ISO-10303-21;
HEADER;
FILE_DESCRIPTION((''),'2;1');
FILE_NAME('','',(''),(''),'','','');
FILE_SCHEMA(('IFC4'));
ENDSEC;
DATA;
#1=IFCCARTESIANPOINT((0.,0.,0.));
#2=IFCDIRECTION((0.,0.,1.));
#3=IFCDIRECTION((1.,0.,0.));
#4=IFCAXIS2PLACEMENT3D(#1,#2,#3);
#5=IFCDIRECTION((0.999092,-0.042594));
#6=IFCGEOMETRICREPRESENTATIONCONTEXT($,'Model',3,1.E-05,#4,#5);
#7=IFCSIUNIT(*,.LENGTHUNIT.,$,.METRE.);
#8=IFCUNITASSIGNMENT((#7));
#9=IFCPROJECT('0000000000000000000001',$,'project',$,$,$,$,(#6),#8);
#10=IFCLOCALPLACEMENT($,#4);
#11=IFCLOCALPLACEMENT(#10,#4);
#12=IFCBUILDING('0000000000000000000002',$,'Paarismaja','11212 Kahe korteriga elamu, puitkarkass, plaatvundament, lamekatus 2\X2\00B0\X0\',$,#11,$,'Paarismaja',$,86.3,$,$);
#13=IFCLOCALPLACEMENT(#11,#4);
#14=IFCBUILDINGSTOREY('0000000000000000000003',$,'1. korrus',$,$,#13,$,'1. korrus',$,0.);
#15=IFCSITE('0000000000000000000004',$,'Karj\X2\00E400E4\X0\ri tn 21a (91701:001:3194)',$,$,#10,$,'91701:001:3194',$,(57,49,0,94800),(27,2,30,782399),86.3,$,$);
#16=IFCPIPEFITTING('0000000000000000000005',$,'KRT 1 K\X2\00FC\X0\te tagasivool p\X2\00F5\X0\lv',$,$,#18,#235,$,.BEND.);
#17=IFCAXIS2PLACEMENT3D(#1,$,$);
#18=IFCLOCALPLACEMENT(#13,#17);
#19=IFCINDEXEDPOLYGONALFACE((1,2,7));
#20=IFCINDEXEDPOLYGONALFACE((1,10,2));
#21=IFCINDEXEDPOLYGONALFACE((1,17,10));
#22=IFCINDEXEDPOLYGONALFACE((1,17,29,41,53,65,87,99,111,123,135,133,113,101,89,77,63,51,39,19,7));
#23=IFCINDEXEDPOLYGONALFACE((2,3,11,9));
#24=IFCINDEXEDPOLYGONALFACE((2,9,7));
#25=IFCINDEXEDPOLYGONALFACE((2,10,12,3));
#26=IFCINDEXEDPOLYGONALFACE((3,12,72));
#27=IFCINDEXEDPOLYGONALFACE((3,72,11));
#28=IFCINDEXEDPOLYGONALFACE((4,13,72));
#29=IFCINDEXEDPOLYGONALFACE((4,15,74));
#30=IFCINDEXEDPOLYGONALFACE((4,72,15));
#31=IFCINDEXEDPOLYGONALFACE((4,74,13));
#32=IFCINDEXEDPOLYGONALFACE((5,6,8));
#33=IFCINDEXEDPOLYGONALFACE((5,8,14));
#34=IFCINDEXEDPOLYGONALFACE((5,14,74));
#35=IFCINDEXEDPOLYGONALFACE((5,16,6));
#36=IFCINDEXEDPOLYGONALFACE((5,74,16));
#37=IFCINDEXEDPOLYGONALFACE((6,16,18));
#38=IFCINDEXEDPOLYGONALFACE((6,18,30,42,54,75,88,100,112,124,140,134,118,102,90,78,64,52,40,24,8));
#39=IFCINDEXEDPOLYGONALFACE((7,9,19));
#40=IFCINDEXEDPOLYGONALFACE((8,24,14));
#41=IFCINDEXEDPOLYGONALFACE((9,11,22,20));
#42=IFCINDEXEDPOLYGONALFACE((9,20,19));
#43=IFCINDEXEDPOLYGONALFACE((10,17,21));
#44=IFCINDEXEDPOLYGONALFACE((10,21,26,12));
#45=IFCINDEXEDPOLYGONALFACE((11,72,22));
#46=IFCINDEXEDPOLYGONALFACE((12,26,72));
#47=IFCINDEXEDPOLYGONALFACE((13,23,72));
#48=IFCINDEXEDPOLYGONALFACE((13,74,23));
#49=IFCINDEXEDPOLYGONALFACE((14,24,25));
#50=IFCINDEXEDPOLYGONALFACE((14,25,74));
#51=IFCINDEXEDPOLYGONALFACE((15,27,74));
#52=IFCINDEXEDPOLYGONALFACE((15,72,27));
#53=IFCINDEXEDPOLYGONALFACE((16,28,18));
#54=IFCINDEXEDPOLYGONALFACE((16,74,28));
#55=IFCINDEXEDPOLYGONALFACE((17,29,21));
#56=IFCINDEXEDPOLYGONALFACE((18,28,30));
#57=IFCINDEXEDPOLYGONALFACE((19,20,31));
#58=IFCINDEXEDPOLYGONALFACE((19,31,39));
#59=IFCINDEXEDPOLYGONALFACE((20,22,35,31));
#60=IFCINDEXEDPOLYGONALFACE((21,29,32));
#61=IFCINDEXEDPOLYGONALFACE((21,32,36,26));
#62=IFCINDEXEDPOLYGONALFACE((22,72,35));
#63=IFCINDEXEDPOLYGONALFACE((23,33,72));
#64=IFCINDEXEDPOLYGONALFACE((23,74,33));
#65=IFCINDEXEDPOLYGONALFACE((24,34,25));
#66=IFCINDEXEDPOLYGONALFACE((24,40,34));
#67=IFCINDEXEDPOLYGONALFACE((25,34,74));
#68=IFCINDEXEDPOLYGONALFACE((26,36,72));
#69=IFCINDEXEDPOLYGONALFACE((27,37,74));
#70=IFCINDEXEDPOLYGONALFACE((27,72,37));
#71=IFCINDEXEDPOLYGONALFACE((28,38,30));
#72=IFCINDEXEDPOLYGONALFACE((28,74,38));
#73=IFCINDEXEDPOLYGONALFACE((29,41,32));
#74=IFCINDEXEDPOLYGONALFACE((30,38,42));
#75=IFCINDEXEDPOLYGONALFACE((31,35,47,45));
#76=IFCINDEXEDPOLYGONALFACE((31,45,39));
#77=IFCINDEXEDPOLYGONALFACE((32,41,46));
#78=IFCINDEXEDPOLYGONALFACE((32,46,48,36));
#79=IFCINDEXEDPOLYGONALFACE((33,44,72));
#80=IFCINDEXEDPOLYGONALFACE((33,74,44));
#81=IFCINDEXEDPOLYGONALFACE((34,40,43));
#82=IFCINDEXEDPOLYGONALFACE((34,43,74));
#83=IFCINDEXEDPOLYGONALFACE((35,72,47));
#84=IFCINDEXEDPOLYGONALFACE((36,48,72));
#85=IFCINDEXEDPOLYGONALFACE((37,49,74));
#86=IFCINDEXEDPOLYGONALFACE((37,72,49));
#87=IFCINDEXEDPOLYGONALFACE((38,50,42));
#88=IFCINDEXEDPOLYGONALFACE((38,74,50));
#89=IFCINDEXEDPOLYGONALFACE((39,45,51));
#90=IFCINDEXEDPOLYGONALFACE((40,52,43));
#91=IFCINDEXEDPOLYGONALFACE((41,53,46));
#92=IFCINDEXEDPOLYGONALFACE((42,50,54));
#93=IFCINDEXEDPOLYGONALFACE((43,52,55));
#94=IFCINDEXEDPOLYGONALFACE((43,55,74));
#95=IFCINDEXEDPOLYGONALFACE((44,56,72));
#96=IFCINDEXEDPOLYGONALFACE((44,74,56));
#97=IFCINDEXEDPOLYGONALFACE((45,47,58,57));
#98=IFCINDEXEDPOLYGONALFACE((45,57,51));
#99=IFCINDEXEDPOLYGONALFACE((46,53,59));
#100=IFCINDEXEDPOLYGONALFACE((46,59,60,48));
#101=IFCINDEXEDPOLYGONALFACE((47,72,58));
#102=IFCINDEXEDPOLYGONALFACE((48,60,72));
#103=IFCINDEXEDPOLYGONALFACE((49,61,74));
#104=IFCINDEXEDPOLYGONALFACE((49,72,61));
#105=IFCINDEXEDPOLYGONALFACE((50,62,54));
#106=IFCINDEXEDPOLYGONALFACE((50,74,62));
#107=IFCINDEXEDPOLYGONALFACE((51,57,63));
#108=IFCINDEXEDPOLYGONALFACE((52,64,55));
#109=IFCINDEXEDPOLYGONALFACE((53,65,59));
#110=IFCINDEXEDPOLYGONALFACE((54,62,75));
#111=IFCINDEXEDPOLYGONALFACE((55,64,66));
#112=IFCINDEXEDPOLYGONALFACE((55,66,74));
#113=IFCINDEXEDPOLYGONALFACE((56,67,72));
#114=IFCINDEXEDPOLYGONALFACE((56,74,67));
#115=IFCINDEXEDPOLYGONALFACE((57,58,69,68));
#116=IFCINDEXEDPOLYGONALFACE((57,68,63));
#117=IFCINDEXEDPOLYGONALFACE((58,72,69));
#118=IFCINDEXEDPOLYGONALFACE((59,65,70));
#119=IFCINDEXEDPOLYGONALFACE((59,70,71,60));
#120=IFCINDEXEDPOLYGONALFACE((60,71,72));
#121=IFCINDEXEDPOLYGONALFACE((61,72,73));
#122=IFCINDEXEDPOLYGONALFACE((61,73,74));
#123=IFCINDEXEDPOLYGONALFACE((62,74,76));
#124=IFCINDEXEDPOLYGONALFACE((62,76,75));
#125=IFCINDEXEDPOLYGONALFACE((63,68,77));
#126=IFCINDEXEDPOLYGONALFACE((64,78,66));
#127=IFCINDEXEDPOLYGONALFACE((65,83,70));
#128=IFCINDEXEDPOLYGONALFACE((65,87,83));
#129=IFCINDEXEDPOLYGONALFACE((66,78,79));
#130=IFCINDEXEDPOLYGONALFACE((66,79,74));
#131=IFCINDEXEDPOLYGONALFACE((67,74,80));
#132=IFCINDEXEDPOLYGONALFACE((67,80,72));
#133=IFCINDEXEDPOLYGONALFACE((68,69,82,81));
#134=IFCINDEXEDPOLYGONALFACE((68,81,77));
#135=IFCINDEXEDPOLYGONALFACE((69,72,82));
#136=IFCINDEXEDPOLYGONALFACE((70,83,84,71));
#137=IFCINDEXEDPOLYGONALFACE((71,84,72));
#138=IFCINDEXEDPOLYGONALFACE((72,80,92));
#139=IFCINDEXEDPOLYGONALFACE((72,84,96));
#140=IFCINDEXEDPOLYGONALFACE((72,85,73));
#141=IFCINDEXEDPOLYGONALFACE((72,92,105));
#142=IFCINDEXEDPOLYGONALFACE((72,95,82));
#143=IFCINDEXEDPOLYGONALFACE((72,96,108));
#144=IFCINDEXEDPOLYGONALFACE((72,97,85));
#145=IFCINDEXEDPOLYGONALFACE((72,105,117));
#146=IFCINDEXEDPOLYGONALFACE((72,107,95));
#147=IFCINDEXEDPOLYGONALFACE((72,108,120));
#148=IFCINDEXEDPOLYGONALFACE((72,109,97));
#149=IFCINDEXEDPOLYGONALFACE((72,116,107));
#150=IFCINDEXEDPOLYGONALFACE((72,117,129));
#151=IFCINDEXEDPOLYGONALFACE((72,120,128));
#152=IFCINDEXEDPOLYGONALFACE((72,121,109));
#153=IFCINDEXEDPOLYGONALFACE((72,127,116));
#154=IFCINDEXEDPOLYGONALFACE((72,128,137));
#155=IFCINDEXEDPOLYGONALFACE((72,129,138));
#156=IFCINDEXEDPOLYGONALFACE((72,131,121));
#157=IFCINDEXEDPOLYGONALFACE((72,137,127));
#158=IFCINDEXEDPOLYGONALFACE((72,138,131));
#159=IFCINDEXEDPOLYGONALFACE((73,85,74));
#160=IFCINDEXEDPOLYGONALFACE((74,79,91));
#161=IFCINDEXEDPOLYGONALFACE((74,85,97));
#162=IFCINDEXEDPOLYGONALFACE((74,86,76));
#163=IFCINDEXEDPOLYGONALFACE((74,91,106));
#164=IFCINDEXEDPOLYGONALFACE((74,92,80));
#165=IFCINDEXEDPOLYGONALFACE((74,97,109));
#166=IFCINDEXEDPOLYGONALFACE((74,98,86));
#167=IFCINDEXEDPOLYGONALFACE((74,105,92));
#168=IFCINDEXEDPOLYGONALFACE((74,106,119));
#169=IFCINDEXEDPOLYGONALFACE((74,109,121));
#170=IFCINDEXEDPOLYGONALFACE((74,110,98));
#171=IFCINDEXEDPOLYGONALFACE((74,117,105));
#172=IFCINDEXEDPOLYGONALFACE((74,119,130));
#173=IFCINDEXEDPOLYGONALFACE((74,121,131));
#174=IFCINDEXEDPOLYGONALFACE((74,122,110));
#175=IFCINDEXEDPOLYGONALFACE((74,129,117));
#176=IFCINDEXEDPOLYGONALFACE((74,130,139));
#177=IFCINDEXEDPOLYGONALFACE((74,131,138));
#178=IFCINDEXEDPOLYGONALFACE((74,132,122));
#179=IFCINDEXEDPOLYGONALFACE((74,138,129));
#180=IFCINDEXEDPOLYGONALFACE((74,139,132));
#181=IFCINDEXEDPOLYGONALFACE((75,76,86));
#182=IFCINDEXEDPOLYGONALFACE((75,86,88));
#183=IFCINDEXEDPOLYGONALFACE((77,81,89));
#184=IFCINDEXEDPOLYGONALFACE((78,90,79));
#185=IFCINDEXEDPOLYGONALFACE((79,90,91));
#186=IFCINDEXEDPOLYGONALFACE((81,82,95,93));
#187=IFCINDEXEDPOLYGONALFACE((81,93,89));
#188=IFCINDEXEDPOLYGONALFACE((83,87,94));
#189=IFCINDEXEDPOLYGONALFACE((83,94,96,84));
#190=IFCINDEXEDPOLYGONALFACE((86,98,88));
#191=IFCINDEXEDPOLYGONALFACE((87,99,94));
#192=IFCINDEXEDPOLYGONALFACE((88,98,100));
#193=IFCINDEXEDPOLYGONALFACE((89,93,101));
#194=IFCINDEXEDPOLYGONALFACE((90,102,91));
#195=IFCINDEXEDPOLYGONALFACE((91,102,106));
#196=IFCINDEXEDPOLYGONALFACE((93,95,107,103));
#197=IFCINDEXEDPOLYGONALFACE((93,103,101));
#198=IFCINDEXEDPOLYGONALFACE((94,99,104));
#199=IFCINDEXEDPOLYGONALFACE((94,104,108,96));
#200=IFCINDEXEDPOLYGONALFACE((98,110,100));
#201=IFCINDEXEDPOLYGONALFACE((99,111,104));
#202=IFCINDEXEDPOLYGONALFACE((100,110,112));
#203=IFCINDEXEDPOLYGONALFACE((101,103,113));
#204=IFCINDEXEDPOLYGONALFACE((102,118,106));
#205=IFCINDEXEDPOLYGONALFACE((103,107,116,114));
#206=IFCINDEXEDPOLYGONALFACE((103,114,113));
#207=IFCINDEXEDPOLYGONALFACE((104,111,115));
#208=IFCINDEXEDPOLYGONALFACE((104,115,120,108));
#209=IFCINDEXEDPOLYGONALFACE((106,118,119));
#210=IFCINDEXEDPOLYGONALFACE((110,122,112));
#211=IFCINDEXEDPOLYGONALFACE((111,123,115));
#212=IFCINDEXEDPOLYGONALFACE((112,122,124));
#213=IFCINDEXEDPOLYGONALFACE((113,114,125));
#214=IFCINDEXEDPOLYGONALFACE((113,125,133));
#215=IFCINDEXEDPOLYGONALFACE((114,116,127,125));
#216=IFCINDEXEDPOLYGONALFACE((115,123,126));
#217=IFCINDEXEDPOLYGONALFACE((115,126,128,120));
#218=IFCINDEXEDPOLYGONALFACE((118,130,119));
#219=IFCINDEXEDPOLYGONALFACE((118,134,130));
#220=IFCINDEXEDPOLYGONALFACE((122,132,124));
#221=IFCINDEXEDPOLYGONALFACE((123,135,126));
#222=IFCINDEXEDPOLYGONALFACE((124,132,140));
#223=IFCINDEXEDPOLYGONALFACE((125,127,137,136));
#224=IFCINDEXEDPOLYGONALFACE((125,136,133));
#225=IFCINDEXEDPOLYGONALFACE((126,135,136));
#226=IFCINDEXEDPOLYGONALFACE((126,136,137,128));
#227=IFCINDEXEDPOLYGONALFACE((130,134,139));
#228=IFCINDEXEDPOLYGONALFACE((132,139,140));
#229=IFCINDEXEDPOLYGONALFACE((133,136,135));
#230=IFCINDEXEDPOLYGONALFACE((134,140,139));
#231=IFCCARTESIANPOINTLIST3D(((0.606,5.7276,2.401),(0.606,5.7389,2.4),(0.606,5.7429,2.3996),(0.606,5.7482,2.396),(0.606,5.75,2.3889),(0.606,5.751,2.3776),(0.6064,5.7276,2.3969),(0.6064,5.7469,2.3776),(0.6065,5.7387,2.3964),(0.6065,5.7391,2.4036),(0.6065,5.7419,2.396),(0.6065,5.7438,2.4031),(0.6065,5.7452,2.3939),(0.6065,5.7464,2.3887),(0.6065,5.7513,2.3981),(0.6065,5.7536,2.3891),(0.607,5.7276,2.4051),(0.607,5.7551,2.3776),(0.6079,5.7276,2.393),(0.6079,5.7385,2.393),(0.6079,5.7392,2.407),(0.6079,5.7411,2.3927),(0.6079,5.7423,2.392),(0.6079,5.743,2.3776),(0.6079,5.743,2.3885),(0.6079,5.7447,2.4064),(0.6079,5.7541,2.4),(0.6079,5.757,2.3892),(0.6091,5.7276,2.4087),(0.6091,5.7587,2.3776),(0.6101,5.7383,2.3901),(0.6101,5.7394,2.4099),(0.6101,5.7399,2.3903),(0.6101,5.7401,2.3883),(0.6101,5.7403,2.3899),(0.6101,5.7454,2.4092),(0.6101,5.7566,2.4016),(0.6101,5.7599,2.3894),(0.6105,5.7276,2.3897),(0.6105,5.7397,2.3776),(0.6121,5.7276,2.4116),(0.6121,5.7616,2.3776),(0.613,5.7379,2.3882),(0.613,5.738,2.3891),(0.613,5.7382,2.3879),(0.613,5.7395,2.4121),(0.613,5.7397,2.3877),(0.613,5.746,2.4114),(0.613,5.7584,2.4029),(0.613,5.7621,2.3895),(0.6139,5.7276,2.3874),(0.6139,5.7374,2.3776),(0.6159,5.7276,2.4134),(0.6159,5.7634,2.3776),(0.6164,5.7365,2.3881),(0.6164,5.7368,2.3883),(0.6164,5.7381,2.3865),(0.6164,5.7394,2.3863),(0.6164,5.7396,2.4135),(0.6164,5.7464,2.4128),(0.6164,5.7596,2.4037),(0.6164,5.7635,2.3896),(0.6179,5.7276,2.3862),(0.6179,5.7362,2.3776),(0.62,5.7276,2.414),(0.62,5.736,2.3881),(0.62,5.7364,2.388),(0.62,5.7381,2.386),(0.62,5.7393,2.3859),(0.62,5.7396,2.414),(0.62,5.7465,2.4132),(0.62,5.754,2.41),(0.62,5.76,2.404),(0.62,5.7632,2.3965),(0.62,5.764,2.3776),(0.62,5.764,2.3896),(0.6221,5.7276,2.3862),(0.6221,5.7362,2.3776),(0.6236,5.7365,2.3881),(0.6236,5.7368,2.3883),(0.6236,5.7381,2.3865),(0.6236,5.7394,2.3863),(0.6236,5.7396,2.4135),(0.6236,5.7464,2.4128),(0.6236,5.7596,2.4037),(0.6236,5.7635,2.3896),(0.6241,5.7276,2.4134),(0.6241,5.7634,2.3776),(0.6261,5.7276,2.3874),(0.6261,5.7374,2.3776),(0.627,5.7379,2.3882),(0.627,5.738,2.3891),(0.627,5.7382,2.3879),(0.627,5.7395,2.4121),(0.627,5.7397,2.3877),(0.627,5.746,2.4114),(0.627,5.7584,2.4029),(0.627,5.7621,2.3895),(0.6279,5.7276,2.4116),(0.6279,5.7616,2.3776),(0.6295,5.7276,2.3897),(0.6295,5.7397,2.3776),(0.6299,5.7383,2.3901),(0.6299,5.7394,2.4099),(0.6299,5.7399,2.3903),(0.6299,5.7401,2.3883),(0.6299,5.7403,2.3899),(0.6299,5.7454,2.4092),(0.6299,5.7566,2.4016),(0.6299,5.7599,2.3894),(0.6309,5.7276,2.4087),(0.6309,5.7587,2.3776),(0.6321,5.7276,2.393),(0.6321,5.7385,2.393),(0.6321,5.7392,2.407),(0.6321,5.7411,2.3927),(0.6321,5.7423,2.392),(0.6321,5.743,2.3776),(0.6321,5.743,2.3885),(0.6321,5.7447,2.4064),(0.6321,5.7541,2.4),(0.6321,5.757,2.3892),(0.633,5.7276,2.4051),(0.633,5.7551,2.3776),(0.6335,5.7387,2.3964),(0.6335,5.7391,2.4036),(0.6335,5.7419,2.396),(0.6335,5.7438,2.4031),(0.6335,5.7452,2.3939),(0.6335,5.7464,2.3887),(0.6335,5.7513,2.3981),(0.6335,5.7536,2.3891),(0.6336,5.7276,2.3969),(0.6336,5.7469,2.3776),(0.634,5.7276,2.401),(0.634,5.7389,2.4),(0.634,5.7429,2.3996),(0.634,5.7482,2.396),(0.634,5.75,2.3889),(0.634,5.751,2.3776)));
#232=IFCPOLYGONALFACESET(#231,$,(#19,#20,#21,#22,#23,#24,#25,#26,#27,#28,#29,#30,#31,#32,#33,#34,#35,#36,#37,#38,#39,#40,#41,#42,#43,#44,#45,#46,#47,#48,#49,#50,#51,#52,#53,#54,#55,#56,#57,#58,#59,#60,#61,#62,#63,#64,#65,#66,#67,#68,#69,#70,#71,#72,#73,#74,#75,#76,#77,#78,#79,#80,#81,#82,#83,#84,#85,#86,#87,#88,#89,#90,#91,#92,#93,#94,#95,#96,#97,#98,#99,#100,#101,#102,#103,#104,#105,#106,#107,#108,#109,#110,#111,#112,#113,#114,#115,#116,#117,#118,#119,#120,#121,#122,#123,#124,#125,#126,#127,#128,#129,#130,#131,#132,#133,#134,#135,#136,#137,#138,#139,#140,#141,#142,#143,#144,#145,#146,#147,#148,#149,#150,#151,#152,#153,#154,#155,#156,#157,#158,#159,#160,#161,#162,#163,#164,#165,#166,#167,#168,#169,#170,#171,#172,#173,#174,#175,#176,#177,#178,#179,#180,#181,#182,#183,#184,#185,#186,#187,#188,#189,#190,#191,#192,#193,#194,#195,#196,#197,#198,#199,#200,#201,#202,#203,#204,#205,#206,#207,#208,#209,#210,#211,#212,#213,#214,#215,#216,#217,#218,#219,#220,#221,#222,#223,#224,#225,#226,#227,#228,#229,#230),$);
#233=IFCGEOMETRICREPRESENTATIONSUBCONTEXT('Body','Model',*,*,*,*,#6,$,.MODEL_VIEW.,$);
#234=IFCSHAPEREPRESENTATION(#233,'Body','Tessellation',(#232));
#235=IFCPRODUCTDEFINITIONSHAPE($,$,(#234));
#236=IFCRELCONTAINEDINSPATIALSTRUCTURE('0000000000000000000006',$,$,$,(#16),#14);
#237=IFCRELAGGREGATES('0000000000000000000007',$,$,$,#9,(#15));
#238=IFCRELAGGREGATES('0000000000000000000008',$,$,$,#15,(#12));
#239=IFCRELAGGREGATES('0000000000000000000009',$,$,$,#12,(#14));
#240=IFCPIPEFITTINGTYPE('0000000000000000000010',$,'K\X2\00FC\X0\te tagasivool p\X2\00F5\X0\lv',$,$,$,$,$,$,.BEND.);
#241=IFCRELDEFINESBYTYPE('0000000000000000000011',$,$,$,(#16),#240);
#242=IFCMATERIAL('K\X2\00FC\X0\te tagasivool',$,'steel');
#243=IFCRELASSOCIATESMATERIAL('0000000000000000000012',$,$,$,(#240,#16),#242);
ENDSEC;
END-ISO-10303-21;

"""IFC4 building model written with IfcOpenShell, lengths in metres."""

from ifc_helpers import new_model, entity, si_unit, direction, frame, origin_with_axes, place, context, subcontext, project, spatial, material, type_object, element, save


model = new_model("IFC4")

# Units and contexts
model_context = context("Model", 3, precision=1e-05, world=origin_with_axes(), true_north=direction((0.999092, -0.042594)))
body_context = subcontext(model_context, "Body", "Model", "MODEL_VIEW")
ifc_project = project(units=[si_unit("LENGTHUNIT", "METRE")], contexts=[model_context])

# Site, building, storey
site_placement = place(None, origin_with_axes())
site = spatial("IfcSite", under=ifc_project, at=site_placement, Name="Karjääri tn 21a (91701:001:3194)", LongName="91701:001:3194", RefLatitude=(57, 49, 0, 94800), RefLongitude=(27, 2, 30, 782399), RefElevation=86.3)
building_placement = place(site_placement, origin_with_axes())
building = spatial("IfcBuilding", under=site, at=building_placement, Name="Paarismaja", Description="11212 Kahe korteriga elamu, puitkarkass, plaatvundament, lamekatus 2°", LongName="Paarismaja", ElevationOfRefHeight=86.3)
storey_placement = place(building_placement, origin_with_axes())
storey = spatial("IfcBuildingStorey", under=building, at=storey_placement, Name="1. korrus", LongName="1. korrus", Elevation=0.0)

# Pipe fitting
ifc_material_1 = material(Name="Küte tagasivool", Category="steel")
pipe_fitting_type_1 = type_object("IfcPipeFittingType", Name="Küte tagasivool põlv", PredefinedType="BEND", material=ifc_material_1)
pipe_fitting_1_placement = place(storey_placement, frame((0.62, 5.75, 2.4), z_axis=(0.0, 0.0, 1.0), x_axis=(1.0, 0.0, 0.0)))
element("IfcPipeFitting", 1, at=pipe_fitting_1_placement, inside=storey, type_object=pipe_fitting_type_1, material=ifc_material_1, Name="KRT 1 Küte tagasivool põlv", PredefinedType="BEND", context=body_context, shape_type="AdvancedSweptSolid", body=[
    entity("IfcSweptDiskSolid", entity("IfcIndexedPolyCurve", entity("IfcCartesianPointList3D", [[0.0, -0.0224, 0.0], [0.0, -0.0111, 0.0], [0.0, -0.0071, -0.0004], [0.0, -0.004, -0.0018], [0.0, -0.0018, -0.004], [0.0, -0.0004, -0.0071], [0.0, 0.0, -0.0111], [0.0, 0.0, -0.0224]]), None, False), 0.014),
])

save(model, "model.ifc")
